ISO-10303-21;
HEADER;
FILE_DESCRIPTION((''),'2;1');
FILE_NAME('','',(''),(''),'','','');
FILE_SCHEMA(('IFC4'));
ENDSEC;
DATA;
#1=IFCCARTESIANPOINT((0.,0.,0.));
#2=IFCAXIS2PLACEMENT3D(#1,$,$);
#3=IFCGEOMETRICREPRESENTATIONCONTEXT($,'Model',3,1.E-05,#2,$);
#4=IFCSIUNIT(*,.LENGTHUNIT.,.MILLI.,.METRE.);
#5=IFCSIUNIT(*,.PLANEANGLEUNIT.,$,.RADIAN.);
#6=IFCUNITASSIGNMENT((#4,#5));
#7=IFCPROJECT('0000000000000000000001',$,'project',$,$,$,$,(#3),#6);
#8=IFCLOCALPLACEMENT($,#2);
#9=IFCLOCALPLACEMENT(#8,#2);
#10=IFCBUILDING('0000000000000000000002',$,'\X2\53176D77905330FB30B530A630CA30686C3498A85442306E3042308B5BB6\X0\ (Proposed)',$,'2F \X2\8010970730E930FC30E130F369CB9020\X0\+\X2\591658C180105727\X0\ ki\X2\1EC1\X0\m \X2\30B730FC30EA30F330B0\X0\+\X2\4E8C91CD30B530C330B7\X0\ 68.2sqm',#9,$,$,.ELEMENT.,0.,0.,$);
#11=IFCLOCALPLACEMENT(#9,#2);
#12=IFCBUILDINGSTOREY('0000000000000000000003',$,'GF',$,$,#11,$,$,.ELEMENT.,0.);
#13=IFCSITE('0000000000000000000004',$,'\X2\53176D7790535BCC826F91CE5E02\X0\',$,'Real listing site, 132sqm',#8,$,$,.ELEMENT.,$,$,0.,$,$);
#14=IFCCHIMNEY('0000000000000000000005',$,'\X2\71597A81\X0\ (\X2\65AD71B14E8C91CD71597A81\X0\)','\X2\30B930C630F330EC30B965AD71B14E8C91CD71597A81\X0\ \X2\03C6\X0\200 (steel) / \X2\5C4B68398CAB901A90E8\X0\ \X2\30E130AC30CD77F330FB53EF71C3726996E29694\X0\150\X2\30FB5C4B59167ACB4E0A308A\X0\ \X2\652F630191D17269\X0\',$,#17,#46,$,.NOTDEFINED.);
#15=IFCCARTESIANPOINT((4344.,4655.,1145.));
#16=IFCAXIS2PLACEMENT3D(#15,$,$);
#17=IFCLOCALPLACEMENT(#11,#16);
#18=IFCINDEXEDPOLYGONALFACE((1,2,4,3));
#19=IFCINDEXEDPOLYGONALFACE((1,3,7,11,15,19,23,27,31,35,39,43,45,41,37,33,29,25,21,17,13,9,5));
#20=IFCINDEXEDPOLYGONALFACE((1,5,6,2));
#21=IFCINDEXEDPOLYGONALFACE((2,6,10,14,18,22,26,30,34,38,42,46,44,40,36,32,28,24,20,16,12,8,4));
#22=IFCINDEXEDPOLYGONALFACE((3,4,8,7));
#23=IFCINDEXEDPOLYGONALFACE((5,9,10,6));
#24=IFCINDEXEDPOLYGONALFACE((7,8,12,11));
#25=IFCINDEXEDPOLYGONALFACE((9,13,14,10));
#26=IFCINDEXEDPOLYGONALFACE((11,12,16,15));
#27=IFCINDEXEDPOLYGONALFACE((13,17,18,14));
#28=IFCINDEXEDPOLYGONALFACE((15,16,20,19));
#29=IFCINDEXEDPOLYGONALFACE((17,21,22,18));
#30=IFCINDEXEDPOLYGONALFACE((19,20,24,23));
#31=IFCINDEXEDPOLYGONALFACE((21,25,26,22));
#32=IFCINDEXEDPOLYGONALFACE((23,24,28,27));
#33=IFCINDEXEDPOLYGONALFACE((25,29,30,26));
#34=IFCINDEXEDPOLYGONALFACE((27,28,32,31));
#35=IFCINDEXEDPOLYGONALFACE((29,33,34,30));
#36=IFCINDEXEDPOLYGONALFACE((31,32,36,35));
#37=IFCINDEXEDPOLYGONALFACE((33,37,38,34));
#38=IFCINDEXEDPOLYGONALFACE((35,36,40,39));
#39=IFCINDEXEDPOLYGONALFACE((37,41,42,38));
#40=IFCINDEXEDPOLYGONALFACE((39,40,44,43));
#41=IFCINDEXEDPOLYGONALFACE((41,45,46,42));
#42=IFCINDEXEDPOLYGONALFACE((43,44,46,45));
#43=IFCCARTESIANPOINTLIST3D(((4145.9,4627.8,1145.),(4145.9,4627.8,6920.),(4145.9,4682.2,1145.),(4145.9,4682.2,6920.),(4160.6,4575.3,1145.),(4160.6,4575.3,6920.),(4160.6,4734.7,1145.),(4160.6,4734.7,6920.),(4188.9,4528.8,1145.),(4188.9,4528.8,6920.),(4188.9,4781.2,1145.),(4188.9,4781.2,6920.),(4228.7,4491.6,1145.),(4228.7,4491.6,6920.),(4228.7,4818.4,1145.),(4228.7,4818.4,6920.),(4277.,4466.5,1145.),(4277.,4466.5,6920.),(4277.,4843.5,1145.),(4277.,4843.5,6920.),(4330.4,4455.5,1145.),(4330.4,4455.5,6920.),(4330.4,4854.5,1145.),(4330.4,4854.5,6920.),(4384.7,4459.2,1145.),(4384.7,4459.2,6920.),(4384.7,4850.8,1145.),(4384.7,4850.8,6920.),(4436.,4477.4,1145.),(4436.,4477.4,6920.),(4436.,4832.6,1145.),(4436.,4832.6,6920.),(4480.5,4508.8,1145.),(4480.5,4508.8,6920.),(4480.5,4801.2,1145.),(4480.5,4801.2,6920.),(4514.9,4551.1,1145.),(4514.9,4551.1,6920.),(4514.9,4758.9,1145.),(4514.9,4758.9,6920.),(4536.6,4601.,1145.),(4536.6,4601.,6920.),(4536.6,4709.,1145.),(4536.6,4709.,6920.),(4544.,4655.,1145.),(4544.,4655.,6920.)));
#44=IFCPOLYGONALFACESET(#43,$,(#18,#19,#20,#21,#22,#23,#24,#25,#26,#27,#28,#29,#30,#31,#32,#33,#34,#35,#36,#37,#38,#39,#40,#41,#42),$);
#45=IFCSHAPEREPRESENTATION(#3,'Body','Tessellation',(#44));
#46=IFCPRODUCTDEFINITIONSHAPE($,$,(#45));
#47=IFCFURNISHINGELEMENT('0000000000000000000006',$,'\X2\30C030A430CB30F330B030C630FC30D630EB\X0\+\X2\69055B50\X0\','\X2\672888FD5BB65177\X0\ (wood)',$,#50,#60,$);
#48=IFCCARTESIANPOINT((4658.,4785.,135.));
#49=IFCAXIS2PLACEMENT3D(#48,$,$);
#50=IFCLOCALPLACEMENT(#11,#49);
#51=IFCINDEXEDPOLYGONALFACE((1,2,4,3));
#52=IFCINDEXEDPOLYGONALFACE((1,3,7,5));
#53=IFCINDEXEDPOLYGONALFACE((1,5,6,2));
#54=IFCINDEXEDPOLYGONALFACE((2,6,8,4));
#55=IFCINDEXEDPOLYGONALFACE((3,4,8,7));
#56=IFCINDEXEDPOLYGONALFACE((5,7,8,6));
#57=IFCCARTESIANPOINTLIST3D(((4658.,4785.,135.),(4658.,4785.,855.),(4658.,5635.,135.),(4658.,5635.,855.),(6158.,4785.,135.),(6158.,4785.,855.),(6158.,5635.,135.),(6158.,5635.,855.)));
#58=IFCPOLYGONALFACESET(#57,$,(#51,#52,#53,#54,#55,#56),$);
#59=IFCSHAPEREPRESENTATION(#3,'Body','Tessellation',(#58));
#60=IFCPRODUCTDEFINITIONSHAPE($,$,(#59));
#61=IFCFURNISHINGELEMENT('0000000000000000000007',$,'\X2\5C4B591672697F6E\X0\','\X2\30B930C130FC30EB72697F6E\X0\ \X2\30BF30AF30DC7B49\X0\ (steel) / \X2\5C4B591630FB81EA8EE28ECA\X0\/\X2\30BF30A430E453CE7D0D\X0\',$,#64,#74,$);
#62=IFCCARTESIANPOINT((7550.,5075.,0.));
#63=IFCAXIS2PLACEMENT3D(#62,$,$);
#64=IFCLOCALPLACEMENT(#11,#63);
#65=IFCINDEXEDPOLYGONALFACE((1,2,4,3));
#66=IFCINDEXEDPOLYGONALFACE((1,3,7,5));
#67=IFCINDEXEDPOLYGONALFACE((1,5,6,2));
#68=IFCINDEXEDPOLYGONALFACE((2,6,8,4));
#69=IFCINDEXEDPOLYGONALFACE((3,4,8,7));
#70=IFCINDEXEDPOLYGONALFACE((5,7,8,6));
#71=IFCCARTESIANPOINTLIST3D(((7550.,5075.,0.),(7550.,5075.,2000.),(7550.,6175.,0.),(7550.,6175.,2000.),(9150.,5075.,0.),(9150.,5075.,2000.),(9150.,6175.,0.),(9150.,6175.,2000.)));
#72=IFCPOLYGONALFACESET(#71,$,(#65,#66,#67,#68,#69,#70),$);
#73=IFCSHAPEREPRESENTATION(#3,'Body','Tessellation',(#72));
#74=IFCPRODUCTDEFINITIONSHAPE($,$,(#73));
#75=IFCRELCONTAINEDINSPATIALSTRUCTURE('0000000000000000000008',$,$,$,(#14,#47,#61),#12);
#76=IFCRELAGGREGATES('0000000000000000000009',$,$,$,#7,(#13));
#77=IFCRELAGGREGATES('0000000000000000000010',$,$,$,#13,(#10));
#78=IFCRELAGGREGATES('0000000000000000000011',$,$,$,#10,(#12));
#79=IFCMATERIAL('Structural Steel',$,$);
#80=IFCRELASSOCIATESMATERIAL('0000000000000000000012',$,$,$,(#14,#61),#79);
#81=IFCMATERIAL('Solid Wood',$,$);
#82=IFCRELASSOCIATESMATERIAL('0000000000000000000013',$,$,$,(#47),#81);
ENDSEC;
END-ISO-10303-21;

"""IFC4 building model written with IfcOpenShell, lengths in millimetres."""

from ifc_helpers import new_model, si_unit, frame, frame_2d, origin, origin_2d, place, context, project, spatial, rectangle, circle, extrude, material, element, save


model = new_model("IFC4")

# Units and contexts
model_context = context("Model", 3, precision=1e-05, world=origin())
ifc_project = project(units=[si_unit("LENGTHUNIT", "METRE", prefix="MILLI"), si_unit("PLANEANGLEUNIT", "RADIAN")], contexts=[model_context])

# Site, building, storey
site_placement = place(None, origin())
site = spatial("IfcSite", under=ifc_project, at=site_placement, Name="北海道富良野市", ObjectType="Real listing site, 132sqm", CompositionType="ELEMENT", RefElevation=0.0)
building_placement = place(site_placement, origin())
building = spatial("IfcBuilding", under=site, at=building_placement, Name="北海道・サウナと水風呂のある家 (Proposed)", ObjectType="2F 耐震ラーメン構造+外壁耐圧 kiềm シーリング+二重サッシ 68.2sqm", CompositionType="ELEMENT", ElevationOfRefHeight=0.0, ElevationOfTerrain=0.0)
storey_placement = place(building_placement, origin())
storey = spatial("IfcBuildingStorey", under=building, at=storey_placement, Name="GF", CompositionType="ELEMENT", Elevation=0.0)

# Shared definitions
ifc_material_1 = material(Name="Solid Wood")

# Shared definitions
ifc_material_2 = material(Name="Structural Steel")

# Chimney
chimney_placement = place(storey_placement, frame((4344.0, 4655.0, 1145.0)))
element("IfcChimney", 1, at=chimney_placement, inside=storey, material=ifc_material_2, Name="煙突 (断熱二重煙突)", Description="ステンレス断熱二重煙突 φ200 (steel) / 屋根貫通部 メガネ石・可燃物離隔150・屋外立上り 支持金物", PredefinedType="NOTDEFINED", context=model_context, shape_type="SweptSolid", body=[
    extrude(circle(Radius=200.0, at=origin_2d()), frame((4344.0, 4655.0, 1145.0)), (0.0, 0.0, 1.0), 5775.0),
])

# Furnishing elements
furnishing_1_placement = place(storey_placement, frame((4658.0, 4785.0, 135.0)))
element("IfcFurnishingElement", 2, at=furnishing_1_placement, inside=storey, material=ifc_material_1, Name="ダイニングテーブル+椅子", Description="木製家具 (wood)", context=model_context, shape_type="SweptSolid", body=[
    extrude(rectangle(XDim=1500.0, YDim=850.0, at=frame_2d((750.0, 425.0))), frame((4658.0, 4785.0, 135.0)), (0.0, 0.0, 1.0), 720.0),
])
furnishing_2_placement = place(storey_placement, frame((7550.0, 5075.0, 0.0)))
element("IfcFurnishingElement", 3, at=furnishing_2_placement, inside=storey, material=ifc_material_2, Name="屋外物置", Description="スチール物置 タクボ等 (steel) / 屋外・自転車/タイヤ収納", context=model_context, shape_type="SweptSolid", body=[
    extrude(rectangle(XDim=1600.0, YDim=1100.0, at=frame_2d((800.0, 550.0))), frame((7550.0, 5075.0, 0.0)), (0.0, 0.0, 1.0), 2000.0),
])

save(model, "model.ifc")
